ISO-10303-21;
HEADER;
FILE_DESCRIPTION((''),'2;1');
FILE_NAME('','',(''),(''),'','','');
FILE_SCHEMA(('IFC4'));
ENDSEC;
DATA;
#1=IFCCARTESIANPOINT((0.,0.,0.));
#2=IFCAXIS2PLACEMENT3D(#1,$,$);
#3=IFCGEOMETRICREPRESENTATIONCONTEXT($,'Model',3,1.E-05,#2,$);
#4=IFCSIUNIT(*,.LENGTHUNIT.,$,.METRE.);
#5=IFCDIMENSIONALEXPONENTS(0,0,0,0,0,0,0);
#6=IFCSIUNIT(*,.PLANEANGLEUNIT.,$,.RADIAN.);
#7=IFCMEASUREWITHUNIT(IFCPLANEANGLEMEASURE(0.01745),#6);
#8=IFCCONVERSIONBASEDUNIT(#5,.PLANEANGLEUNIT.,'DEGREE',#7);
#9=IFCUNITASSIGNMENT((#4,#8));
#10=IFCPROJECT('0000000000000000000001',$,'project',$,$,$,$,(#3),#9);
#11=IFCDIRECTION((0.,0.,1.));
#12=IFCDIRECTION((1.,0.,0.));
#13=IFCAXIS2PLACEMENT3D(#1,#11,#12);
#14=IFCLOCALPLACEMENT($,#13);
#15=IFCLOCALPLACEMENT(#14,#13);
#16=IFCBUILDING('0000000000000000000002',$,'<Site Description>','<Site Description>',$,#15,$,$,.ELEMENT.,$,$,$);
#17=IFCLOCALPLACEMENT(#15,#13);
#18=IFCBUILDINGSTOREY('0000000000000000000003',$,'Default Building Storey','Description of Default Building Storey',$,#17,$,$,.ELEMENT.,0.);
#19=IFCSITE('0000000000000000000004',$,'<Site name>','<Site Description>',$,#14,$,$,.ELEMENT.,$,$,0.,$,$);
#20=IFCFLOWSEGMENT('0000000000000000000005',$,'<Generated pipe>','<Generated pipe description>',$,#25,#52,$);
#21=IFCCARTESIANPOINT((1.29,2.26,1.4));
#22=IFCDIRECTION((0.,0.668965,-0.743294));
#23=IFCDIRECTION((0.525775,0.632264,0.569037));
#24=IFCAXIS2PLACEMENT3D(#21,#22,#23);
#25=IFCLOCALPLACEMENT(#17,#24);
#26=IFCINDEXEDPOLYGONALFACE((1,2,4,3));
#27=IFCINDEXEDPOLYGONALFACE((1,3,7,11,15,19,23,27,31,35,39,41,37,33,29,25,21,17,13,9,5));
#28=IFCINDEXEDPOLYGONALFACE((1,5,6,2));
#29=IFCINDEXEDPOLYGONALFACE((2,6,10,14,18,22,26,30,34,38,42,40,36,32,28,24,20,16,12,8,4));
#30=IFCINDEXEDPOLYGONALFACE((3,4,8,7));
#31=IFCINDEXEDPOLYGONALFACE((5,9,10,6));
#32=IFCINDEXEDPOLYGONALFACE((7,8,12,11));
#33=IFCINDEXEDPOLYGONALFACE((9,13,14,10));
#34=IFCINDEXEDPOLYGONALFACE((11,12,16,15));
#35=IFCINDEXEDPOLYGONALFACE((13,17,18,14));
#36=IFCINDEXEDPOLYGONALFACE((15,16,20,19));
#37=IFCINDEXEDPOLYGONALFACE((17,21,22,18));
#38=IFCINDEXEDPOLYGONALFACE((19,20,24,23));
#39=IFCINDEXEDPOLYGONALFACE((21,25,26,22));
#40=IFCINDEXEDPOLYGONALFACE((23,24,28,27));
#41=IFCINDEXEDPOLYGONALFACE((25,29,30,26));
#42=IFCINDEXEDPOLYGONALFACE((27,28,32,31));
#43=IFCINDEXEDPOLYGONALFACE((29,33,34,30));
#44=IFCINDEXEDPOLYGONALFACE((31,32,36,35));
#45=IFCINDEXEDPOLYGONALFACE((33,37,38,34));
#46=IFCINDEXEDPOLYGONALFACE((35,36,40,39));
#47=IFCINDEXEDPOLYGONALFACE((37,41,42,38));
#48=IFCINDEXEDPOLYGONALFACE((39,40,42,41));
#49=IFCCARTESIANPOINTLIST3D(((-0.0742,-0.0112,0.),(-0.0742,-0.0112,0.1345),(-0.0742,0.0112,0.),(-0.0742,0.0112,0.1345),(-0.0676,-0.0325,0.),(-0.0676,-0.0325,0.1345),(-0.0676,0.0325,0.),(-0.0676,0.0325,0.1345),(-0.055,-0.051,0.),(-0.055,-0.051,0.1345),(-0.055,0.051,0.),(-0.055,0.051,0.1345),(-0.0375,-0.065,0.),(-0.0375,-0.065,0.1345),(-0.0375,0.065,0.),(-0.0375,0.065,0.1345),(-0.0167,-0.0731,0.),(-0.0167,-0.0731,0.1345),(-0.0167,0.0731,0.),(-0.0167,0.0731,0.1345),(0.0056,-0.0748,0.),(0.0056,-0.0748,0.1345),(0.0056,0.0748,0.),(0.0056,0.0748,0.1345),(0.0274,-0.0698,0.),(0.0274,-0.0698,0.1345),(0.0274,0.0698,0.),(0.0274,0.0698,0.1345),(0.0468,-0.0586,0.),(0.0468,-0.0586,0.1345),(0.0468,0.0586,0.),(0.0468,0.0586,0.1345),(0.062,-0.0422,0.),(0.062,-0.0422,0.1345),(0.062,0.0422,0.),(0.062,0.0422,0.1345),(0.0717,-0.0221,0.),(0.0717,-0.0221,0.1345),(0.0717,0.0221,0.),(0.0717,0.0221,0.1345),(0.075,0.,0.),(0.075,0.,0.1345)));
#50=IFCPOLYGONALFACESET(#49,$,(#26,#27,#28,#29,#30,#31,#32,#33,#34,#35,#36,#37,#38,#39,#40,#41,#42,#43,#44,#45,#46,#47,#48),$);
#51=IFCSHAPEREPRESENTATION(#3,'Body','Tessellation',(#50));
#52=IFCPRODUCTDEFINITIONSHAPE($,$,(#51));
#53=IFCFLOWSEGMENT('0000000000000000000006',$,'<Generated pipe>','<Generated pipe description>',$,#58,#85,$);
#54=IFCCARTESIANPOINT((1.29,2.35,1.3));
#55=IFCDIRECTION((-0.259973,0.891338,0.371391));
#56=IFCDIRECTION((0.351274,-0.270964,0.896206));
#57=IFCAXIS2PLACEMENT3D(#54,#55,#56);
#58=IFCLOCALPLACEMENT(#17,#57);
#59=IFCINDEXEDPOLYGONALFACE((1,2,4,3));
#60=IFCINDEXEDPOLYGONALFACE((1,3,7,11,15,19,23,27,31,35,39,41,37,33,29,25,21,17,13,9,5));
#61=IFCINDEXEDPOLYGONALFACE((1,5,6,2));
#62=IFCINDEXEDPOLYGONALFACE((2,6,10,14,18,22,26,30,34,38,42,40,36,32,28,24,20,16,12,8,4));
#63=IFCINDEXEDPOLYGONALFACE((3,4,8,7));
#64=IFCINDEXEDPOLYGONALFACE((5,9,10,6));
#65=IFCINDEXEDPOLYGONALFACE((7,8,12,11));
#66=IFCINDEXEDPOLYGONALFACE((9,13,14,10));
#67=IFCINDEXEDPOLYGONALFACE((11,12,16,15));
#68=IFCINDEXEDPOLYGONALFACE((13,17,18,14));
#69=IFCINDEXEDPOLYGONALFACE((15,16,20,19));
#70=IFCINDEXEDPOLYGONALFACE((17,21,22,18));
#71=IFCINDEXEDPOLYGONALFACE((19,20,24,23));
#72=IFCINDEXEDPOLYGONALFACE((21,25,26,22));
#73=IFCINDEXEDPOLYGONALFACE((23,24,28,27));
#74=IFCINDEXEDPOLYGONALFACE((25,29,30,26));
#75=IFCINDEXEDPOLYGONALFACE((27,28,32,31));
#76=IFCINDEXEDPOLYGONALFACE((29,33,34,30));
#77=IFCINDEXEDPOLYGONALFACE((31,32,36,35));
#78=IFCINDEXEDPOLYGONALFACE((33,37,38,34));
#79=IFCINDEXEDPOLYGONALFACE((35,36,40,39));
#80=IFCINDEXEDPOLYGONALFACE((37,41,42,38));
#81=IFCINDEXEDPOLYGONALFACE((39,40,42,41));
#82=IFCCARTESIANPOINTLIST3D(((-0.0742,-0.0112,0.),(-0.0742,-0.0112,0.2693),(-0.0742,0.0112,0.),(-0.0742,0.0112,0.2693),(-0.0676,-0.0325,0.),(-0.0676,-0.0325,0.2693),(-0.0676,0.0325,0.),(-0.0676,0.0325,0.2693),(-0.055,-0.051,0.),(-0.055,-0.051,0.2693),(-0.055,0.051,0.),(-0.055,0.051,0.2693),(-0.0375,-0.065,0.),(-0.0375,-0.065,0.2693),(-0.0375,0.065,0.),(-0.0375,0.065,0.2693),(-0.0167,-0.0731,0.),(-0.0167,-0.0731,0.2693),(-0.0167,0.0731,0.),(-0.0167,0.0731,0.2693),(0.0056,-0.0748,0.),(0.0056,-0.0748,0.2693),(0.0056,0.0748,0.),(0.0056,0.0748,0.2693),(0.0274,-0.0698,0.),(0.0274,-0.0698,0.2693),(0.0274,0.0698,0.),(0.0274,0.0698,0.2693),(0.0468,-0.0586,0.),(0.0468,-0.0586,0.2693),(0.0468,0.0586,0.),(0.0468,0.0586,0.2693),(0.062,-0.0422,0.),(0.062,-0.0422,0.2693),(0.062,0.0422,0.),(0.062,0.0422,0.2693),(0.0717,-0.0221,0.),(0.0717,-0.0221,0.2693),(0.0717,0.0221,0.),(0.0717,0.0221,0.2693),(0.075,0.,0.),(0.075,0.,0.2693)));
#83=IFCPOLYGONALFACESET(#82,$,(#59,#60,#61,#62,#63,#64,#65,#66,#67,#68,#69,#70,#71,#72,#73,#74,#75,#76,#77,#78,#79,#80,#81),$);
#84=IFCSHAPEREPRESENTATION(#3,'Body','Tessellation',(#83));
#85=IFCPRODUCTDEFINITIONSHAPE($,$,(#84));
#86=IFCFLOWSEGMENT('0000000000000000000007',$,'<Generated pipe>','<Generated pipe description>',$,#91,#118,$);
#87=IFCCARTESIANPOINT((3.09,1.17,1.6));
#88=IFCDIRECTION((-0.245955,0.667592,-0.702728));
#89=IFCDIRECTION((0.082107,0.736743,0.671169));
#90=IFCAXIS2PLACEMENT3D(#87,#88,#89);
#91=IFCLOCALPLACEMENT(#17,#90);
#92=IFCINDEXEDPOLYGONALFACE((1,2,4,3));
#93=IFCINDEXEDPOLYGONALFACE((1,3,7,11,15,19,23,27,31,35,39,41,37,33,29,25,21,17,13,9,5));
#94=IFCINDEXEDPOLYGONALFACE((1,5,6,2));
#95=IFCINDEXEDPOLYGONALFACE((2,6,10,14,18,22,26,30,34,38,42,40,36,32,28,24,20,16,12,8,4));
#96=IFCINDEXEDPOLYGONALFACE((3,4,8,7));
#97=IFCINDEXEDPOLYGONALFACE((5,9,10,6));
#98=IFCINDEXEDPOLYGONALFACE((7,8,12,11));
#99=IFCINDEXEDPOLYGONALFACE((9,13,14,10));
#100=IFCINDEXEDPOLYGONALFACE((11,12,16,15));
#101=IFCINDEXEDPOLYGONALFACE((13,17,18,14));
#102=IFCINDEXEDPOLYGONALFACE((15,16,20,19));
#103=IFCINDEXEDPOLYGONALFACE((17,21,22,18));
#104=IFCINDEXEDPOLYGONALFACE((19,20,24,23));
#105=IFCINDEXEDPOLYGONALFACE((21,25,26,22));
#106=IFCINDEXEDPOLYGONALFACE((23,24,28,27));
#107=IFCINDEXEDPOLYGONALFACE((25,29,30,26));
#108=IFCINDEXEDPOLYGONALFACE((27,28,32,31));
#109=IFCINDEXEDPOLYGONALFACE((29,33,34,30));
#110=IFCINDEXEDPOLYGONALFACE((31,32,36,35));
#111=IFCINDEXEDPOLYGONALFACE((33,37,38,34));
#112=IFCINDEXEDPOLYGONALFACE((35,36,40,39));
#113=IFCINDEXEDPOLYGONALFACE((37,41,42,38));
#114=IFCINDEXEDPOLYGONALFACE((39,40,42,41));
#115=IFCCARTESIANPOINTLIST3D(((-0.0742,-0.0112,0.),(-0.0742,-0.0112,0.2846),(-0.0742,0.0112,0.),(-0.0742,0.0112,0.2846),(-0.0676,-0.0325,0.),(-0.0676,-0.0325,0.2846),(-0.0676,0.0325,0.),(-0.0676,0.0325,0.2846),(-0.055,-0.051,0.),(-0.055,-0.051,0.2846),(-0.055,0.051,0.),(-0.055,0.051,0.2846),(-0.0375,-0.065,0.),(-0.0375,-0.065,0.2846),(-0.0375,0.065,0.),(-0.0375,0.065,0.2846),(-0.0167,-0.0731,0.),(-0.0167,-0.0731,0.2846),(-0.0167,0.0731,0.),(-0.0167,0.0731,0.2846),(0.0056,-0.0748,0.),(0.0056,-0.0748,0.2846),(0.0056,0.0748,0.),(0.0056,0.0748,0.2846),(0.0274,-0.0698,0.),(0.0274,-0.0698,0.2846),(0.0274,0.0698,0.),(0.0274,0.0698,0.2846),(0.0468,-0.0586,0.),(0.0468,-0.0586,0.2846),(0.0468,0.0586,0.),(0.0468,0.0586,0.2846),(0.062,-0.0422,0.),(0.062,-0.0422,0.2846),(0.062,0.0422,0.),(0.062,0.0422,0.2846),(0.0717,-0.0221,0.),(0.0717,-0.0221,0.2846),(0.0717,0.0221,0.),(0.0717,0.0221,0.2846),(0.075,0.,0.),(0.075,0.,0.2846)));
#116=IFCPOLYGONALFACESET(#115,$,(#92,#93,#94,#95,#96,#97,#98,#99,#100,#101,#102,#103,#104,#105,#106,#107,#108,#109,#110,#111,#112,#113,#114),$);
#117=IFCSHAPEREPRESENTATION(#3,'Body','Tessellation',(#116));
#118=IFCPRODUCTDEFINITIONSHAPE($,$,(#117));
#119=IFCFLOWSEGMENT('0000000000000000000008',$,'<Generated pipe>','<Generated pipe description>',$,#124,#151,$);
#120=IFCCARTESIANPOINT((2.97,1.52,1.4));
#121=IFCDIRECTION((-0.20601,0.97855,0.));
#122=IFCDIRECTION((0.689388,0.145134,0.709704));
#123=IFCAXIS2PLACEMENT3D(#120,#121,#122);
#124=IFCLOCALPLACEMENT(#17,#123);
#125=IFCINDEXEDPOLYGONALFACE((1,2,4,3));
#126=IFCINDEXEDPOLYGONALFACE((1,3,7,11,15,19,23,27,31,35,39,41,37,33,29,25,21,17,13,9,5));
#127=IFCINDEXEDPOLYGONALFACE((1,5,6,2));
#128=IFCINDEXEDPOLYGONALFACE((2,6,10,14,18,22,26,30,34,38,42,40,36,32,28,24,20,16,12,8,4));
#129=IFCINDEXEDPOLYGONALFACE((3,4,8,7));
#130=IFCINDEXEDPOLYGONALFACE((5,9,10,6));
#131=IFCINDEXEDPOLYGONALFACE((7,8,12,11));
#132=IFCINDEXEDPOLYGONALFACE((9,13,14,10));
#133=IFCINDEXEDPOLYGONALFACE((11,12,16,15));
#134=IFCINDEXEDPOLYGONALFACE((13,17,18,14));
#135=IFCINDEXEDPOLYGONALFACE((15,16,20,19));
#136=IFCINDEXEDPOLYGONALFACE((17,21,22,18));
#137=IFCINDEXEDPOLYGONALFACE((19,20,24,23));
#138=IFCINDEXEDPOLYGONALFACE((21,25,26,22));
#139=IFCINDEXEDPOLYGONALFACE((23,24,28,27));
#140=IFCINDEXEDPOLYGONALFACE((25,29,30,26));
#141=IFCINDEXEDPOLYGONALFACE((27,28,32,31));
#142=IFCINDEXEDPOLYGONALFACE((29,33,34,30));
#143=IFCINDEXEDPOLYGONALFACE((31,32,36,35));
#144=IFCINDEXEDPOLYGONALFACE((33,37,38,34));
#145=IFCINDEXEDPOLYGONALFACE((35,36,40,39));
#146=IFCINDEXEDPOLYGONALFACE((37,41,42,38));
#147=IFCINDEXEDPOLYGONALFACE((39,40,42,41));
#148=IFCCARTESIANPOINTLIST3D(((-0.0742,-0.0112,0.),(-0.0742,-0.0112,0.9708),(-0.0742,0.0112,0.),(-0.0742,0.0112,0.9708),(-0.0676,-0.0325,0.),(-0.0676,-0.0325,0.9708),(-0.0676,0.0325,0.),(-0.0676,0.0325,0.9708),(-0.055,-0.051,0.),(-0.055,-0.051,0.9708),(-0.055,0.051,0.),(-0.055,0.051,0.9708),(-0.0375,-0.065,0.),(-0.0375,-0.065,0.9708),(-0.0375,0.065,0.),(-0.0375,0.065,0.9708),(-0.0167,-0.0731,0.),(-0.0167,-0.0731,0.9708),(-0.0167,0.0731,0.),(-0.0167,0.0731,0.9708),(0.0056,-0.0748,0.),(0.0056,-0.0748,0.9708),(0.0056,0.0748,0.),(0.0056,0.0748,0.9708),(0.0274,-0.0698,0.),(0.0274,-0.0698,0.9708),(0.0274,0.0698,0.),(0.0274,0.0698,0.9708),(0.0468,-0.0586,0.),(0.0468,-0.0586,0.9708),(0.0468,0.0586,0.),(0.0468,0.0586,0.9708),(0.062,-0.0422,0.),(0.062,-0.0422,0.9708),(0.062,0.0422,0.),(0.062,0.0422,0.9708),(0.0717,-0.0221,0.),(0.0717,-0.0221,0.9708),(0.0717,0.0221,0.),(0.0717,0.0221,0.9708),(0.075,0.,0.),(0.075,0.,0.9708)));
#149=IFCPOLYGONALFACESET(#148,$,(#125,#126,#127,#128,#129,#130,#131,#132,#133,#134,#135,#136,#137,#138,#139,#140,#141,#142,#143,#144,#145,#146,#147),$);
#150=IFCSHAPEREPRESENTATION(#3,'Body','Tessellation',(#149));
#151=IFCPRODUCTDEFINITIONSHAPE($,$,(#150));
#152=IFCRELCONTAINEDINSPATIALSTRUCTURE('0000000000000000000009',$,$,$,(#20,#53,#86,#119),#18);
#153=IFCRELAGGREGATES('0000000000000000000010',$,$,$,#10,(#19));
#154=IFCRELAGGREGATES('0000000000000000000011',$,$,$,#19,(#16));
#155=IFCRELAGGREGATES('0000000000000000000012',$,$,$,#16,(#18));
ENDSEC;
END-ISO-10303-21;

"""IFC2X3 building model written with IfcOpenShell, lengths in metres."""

from ifc_helpers import new_model, entity, si_unit, converted_unit, frame, origin, origin_with_axes, origin_2d_with_axis, place, context, project, spatial, circle, extrude, element, save


model = new_model("IFC2X3")

# Units and contexts
model_context = context("Model", 3, precision=1e-05, world=origin())
ifc_project = project(units=[si_unit("LENGTHUNIT", "METRE"), converted_unit("PLANEANGLEUNIT", "DEGREE", entity("IfcPlaneAngleMeasure", 0.01745), si_unit("PLANEANGLEUNIT", "RADIAN"), dimensions=[0, 0, 0, 0, 0, 0, 0])], contexts=[model_context])

# Site, building, storey
site_placement = place(None, origin_with_axes())
site = spatial("IfcSite", under=ifc_project, at=site_placement, Name="<Site name>", Description="<Site Description>", CompositionType="ELEMENT", RefElevation=0.0)
building_placement = place(site_placement, origin_with_axes())
building = spatial("IfcBuilding", under=site, at=building_placement, Name="<Site Description>", Description="<Site Description>", CompositionType="ELEMENT")
storey_placement = place(building_placement, origin_with_axes())
storey = spatial("IfcBuildingStorey", under=building, at=storey_placement, Name="Default Building Storey", Description="Description of Default Building Storey", CompositionType="ELEMENT", Elevation=0.0)

# Flow segments
flow_segment_1_placement = place(storey_placement, frame((1.29, 2.26, 1.4), z_axis=(0.0, 0.668965, -0.743294), x_axis=(0.525775, 0.632264, 0.569037)))
element("IfcFlowSegment", 1, at=flow_segment_1_placement, inside=storey, Name="<Generated pipe>", Description="<Generated pipe description>", context=model_context, shape_type="SweptSolid", body=[
    extrude(circle(Radius=0.075, at=origin_2d_with_axis()), origin_with_axes(), (0.0, 0.0, 1.0), 0.1345),
])
flow_segment_2_placement = place(storey_placement, frame((1.29, 2.35, 1.3), z_axis=(-0.259973, 0.891338, 0.371391), x_axis=(0.351274, -0.270964, 0.896206)))
element("IfcFlowSegment", 2, at=flow_segment_2_placement, inside=storey, Name="<Generated pipe>", Description="<Generated pipe description>", context=model_context, shape_type="SweptSolid", body=[
    extrude(circle(Radius=0.075, at=origin_2d_with_axis()), origin_with_axes(), (0.0, 0.0, 1.0), 0.2693),
])
flow_segment_3_placement = place(storey_placement, frame((3.09, 1.17, 1.6), z_axis=(-0.245955, 0.667592, -0.702728), x_axis=(0.082107, 0.736743, 0.671169)))
element("IfcFlowSegment", 3, at=flow_segment_3_placement, inside=storey, Name="<Generated pipe>", Description="<Generated pipe description>", context=model_context, shape_type="SweptSolid", body=[
    extrude(circle(Radius=0.075, at=origin_2d_with_axis()), origin_with_axes(), (0.0, 0.0, 1.0), 0.2846),
])
flow_segment_4_placement = place(storey_placement, frame((2.97, 1.52, 1.4), z_axis=(-0.20601, 0.97855, 0.0), x_axis=(0.689388, 0.145134, 0.709704)))
element("IfcFlowSegment", 4, at=flow_segment_4_placement, inside=storey, Name="<Generated pipe>", Description="<Generated pipe description>", context=model_context, shape_type="SweptSolid", body=[
    extrude(circle(Radius=0.075, at=origin_2d_with_axis()), origin_with_axes(), (0.0, 0.0, 1.0), 0.9708),
])

save(model, "model.ifc")
